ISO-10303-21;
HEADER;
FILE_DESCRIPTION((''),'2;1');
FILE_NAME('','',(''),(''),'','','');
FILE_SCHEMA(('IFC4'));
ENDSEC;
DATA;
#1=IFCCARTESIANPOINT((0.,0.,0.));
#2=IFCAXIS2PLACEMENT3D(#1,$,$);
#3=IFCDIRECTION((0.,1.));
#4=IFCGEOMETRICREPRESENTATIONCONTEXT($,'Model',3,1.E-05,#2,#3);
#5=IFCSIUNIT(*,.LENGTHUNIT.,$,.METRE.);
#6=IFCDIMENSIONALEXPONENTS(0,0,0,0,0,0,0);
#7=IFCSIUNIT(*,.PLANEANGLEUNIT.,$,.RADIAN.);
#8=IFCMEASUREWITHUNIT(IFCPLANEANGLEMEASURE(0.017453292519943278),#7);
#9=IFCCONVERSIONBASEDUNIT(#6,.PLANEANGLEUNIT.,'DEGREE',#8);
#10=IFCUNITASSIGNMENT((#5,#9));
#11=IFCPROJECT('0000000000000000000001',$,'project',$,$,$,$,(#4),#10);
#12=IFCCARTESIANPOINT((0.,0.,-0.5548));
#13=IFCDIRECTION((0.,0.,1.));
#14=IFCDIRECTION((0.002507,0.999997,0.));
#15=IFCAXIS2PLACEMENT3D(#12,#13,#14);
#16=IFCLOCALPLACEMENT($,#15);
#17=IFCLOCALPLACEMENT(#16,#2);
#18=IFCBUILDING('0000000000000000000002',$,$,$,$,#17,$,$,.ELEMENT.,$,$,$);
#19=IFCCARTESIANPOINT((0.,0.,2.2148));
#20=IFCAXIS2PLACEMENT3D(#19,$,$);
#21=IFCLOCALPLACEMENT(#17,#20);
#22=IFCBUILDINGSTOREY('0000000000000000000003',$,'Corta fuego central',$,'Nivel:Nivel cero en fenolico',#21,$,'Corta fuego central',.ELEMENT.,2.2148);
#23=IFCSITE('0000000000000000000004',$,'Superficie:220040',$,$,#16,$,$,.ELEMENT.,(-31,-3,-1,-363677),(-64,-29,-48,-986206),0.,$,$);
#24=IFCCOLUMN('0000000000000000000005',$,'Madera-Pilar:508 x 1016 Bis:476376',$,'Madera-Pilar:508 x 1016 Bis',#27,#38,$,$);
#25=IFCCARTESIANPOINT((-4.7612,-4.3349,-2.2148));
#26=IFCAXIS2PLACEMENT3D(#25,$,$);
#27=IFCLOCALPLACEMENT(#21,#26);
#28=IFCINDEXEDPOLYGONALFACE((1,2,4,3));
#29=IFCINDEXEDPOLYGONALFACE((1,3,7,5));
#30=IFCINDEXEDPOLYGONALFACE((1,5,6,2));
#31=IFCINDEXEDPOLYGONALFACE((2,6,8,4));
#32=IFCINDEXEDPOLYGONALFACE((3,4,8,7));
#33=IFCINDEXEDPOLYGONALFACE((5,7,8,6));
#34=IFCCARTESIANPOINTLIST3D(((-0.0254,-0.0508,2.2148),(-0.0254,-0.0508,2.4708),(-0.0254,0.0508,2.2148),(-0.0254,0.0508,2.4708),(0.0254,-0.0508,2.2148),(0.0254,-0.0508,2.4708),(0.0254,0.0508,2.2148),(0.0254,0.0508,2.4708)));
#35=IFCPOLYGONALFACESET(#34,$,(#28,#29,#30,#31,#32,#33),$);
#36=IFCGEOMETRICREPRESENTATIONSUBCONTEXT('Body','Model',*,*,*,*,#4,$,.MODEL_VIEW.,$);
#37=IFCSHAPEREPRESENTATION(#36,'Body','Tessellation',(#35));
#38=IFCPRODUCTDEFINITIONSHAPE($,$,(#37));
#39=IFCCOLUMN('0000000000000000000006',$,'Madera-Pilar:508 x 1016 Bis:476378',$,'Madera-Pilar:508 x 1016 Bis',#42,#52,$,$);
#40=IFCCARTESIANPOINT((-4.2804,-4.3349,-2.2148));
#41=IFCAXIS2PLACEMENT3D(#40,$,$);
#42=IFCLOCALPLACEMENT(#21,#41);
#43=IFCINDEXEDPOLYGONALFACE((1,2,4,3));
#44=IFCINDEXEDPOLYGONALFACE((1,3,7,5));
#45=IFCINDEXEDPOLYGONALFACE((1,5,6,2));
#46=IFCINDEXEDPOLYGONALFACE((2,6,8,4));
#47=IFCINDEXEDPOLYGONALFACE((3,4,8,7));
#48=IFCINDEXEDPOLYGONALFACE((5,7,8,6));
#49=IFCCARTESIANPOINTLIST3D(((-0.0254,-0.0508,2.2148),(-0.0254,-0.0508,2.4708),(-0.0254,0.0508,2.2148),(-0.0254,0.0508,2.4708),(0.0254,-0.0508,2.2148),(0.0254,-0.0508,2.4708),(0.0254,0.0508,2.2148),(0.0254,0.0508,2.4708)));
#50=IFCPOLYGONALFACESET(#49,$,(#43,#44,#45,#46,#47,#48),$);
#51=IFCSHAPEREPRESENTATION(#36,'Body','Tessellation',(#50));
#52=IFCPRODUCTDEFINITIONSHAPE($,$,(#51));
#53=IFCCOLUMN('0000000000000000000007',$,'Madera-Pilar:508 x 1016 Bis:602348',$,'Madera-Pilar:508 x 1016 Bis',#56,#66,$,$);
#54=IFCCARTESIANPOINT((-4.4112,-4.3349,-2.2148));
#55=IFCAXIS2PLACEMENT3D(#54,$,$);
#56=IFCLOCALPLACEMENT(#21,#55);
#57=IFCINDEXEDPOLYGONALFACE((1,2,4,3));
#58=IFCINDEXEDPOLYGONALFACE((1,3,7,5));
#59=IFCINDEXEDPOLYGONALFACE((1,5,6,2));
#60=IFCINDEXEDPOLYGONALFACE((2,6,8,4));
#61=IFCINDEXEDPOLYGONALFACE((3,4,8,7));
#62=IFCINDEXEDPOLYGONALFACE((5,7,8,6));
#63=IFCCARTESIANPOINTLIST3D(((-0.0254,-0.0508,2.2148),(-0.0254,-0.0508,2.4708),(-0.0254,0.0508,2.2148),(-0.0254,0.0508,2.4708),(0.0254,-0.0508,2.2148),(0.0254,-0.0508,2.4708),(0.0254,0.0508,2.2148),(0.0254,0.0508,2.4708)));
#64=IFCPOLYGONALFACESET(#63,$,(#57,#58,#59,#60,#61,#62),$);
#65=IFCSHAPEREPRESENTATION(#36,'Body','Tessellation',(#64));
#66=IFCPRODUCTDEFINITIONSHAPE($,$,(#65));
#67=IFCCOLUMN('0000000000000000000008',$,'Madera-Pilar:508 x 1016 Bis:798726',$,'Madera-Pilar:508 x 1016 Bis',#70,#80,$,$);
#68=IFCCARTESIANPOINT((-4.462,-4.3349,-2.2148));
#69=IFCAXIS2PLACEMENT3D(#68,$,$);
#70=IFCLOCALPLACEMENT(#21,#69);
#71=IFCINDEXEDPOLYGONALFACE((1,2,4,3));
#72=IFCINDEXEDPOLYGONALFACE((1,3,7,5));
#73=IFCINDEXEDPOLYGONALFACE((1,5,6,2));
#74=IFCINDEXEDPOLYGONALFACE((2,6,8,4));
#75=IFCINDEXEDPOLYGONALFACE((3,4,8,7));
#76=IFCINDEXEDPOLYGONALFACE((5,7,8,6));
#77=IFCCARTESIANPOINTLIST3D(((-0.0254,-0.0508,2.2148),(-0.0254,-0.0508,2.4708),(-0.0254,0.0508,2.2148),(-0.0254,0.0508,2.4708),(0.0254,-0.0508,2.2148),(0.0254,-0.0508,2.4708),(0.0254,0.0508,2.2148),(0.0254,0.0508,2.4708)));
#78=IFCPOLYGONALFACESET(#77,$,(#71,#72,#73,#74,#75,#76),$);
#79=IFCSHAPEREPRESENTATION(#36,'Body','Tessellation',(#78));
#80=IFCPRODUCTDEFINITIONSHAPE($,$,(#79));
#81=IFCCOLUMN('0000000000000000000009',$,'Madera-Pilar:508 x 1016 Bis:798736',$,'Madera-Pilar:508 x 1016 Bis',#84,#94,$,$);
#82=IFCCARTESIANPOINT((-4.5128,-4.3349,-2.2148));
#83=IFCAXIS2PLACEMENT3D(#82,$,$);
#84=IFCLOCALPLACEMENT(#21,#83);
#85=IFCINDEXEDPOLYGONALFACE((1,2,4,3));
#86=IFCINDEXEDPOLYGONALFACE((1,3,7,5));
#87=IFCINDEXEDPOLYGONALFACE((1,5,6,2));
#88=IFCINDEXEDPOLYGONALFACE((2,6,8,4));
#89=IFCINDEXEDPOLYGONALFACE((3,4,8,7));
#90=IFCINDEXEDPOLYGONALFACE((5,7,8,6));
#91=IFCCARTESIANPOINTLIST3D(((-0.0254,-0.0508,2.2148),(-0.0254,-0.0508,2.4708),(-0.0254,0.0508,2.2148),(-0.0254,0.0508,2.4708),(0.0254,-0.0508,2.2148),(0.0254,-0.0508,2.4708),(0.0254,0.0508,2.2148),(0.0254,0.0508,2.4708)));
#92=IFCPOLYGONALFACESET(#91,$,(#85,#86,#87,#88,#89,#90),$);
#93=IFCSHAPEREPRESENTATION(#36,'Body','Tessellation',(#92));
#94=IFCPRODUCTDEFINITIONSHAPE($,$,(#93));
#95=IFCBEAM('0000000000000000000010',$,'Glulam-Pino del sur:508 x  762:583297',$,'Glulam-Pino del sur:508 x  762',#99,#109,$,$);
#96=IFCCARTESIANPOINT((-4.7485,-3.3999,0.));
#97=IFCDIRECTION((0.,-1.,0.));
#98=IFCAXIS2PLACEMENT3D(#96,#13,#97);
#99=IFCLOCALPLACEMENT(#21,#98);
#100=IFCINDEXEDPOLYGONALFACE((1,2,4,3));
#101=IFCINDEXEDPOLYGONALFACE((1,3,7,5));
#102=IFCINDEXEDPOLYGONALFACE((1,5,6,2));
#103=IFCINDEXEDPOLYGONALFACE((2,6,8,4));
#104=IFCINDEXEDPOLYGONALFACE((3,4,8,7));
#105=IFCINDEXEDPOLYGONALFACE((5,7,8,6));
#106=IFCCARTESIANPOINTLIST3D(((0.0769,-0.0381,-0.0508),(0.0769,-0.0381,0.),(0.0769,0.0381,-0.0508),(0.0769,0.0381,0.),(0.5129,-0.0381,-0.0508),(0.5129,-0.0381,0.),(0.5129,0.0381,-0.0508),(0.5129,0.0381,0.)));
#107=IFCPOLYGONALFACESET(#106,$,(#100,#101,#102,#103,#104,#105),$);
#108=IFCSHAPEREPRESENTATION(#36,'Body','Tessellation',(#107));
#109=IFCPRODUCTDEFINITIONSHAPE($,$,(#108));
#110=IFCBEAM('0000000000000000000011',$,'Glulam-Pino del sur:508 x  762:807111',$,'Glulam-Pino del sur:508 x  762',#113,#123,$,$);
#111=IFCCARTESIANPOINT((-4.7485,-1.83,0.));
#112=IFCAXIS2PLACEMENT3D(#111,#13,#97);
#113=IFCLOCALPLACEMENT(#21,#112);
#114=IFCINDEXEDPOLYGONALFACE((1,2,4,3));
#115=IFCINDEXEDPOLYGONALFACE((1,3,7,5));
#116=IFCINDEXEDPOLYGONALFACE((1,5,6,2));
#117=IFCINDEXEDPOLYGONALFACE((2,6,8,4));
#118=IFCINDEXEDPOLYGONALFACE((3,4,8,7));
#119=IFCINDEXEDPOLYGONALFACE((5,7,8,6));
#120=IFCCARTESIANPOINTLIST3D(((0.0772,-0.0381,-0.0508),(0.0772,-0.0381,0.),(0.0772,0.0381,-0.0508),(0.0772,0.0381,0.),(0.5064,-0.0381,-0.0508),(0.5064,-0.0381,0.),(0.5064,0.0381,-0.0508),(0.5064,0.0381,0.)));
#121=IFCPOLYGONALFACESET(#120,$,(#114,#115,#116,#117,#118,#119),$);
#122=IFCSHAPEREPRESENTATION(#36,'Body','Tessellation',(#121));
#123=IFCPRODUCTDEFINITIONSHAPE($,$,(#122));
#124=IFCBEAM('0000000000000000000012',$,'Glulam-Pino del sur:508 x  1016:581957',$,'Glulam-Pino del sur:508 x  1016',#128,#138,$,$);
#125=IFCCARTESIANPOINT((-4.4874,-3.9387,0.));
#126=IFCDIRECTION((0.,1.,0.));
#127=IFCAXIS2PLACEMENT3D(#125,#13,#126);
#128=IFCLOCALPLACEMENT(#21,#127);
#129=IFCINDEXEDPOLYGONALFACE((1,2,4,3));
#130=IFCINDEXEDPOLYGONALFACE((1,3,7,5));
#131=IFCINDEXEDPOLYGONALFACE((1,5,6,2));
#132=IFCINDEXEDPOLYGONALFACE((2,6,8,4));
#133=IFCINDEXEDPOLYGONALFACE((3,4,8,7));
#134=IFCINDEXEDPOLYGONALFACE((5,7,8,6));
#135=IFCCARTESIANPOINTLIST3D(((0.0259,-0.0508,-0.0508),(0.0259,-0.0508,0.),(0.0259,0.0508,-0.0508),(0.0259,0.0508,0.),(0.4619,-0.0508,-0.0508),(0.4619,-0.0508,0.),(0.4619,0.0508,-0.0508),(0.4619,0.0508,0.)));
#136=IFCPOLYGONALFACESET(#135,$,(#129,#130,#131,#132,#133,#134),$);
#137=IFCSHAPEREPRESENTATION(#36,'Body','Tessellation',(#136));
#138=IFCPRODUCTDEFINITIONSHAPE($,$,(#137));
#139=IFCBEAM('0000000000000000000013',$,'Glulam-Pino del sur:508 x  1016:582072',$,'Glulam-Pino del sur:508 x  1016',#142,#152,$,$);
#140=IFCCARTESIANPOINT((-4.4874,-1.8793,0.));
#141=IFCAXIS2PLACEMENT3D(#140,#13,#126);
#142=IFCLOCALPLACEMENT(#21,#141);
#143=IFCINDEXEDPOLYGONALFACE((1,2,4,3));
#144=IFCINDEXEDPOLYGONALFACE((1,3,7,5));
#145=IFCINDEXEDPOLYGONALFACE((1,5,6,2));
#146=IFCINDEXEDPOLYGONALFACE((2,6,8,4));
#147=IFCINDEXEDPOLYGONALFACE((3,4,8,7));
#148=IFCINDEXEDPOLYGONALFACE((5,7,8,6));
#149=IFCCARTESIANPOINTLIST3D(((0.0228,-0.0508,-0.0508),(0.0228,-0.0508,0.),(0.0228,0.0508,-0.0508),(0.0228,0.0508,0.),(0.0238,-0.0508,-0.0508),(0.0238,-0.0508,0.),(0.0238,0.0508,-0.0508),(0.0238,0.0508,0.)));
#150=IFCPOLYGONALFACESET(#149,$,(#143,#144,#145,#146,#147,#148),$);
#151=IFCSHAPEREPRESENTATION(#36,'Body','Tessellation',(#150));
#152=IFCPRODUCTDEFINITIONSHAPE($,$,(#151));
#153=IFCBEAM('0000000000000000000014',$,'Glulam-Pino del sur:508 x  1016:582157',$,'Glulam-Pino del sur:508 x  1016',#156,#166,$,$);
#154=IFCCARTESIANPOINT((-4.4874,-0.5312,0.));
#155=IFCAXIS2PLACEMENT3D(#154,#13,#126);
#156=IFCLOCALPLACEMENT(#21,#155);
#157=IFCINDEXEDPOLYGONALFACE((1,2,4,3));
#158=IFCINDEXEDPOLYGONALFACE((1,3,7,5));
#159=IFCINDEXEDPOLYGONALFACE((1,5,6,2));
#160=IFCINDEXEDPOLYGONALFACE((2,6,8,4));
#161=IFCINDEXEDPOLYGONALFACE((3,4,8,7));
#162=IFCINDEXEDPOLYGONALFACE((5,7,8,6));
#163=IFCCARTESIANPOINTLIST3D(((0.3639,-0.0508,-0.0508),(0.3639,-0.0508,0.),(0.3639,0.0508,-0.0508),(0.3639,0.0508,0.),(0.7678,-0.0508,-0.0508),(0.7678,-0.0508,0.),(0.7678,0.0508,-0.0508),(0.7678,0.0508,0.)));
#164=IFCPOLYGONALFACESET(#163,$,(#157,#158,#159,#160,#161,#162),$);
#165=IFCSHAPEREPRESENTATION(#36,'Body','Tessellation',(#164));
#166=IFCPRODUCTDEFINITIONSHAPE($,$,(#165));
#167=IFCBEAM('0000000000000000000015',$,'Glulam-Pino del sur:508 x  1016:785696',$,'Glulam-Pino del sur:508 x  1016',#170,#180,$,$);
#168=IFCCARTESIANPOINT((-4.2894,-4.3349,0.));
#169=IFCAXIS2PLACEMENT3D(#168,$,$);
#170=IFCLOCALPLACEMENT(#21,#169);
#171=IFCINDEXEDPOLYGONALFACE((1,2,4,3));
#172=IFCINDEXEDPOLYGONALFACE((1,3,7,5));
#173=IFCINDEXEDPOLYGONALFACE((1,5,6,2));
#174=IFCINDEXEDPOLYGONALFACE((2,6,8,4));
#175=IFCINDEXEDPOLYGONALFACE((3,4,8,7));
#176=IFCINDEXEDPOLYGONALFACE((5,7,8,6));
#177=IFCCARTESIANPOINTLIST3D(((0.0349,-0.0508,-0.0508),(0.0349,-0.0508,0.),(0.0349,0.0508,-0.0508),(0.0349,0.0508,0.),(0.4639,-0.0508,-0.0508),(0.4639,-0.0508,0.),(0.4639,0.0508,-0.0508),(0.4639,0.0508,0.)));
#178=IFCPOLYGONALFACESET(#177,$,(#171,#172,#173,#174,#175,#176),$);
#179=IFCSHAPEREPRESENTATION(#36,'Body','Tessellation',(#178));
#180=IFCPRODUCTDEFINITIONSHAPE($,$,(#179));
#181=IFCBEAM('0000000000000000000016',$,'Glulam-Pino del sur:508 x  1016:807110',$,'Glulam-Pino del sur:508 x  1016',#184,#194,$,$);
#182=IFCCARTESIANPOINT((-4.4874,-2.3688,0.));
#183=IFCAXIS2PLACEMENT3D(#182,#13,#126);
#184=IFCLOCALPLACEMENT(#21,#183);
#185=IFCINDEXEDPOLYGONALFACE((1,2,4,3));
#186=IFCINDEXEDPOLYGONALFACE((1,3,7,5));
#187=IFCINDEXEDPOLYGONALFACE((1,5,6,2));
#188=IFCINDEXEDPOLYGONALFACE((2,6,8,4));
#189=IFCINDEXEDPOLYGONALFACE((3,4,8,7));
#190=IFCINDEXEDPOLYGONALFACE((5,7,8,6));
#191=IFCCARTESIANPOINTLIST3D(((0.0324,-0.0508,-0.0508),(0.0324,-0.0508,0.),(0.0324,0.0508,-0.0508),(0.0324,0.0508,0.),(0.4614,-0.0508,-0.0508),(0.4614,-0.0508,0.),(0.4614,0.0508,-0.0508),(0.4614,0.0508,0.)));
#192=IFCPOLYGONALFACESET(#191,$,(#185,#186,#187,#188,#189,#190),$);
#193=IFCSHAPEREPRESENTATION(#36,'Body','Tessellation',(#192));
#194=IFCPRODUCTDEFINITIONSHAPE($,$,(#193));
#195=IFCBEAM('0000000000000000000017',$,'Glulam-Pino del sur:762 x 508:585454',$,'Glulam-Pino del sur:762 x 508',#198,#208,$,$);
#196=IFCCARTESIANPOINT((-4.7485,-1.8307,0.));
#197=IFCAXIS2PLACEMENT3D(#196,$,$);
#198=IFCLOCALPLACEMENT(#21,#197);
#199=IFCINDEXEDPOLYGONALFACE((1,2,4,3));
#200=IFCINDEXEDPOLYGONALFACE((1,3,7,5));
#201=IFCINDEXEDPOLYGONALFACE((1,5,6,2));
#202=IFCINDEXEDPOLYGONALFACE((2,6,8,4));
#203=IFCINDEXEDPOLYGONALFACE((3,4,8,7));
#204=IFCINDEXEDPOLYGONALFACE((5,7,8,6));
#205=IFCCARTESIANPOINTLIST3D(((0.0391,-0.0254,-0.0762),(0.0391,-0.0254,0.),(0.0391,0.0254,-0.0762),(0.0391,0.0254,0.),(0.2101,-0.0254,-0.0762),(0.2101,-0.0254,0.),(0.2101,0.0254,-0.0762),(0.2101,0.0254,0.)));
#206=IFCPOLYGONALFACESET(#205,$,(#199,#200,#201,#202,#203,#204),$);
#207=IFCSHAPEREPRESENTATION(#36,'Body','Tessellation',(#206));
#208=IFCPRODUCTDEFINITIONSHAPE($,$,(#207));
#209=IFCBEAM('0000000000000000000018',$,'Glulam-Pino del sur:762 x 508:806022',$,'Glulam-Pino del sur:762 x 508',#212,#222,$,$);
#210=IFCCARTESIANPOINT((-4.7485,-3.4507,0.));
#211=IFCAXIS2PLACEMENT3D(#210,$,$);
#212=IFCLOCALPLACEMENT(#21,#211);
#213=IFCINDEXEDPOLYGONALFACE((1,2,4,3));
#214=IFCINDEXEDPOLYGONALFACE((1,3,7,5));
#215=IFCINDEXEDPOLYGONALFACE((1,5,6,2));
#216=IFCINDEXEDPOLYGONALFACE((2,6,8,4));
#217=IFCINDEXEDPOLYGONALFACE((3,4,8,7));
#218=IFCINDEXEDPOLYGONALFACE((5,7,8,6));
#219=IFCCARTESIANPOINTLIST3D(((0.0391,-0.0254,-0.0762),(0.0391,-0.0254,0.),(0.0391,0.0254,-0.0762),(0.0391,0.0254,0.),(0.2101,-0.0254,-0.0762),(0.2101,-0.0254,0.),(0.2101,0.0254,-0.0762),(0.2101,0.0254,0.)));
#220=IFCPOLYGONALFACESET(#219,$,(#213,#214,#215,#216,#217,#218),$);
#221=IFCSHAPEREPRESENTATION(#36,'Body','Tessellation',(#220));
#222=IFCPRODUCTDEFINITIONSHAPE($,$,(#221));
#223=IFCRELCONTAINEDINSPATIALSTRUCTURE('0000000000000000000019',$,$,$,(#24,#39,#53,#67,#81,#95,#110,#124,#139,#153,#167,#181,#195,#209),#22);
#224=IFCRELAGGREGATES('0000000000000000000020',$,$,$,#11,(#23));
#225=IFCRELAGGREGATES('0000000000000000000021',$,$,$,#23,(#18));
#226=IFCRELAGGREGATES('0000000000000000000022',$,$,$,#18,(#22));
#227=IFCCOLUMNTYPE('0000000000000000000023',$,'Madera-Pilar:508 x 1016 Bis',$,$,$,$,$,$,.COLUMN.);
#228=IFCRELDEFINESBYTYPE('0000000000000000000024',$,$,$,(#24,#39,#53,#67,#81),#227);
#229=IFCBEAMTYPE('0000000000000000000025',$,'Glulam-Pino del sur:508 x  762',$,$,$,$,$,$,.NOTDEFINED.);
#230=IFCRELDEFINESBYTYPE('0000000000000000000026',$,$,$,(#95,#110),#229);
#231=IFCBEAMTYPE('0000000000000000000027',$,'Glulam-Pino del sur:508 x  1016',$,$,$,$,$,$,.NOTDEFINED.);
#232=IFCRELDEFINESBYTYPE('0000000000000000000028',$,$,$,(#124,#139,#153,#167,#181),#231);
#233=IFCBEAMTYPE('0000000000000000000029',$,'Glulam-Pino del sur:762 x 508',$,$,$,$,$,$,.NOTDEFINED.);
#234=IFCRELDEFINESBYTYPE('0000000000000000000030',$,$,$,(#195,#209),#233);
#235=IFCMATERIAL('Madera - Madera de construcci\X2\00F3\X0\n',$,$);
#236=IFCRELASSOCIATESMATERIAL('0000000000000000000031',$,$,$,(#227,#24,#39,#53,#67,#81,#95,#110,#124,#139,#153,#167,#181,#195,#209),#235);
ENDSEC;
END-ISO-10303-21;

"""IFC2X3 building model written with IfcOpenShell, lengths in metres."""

from ifc_helpers import new_model, entity, si_unit, converted_unit, direction, frame, frame_2d, origin, origin_2d_with_axis, place, context, subcontext, project, spatial, rectangle, extrude, source, transform, mapped, material, type_object, type_shapes, element, save


model = new_model("IFC2X3")

# Units and contexts
model_context = context("Model", 3, precision=1e-05, world=origin(), true_north=direction((0.0, 1.0)))
body_context = subcontext(model_context, "Body", "Model", "MODEL_VIEW")
ifc_project = project(units=[si_unit("LENGTHUNIT", "METRE"), converted_unit("PLANEANGLEUNIT", "DEGREE", entity("IfcPlaneAngleMeasure", 0.017453292519943278), si_unit("PLANEANGLEUNIT", "RADIAN"), dimensions=[0, 0, 0, 0, 0, 0, 0])], contexts=[model_context])

# Site, building, storey
site_placement = place(None, frame((0.0, 0.0, -0.5548), z_axis=(0.0, 0.0, 1.0), x_axis=(0.002507, 0.999997, 0.0)))
site = spatial("IfcSite", under=ifc_project, at=site_placement, Name="Superficie:220040", CompositionType="ELEMENT", RefLatitude=(-31, -3, -1, -363677), RefLongitude=(-64, -29, -48, -986206), RefElevation=0.0)
building_placement = place(site_placement, origin())
building = spatial("IfcBuilding", under=site, at=building_placement, CompositionType="ELEMENT")
storey_placement = place(building_placement, frame((0.0, 0.0, 2.2148)))
storey = spatial("IfcBuildingStorey", under=building, at=storey_placement, Name="Corta fuego central", ObjectType="Nivel:Nivel cero en fenolico", LongName="Corta fuego central", CompositionType="ELEMENT", Elevation=2.2148)

# Columns
ifc_material_1 = material(Name="Madera - Madera de construcción")
column_type = type_object("IfcColumnType", Name="Madera-Pilar:508 x 1016 Bis", PredefinedType="COLUMN", material=ifc_material_1)
shared_shape = source(origin(), body_context, "Body", "SweptSolid", [
    extrude(rectangle(XDim=0.0508, YDim=0.1016, at=origin_2d_with_axis()), frame((0.0, 0.0, 2.2148), z_axis=(0.0, 0.0, 1.0), x_axis=(-1.0, 0.0, 0.0)), (0.0, 0.0, 1.0), 0.256),
])
type_shapes(column_type, [shared_shape])
for number, where, name in (
    (1, (-4.7612, -4.3349, -2.2148), "Madera-Pilar:508 x 1016 Bis:476376"),
    (2, (-4.2804, -4.3349, -2.2148), "Madera-Pilar:508 x 1016 Bis:476378"),
    (3, (-4.4112, -4.3349, -2.2148), "Madera-Pilar:508 x 1016 Bis:602348"),
    (4, (-4.462, -4.3349, -2.2148), "Madera-Pilar:508 x 1016 Bis:798726"),
    (5, (-4.5128, -4.3349, -2.2148), "Madera-Pilar:508 x 1016 Bis:798736"),
):
    element("IfcColumn", number, at=place(storey_placement, frame(where)), inside=storey, type_object=column_type, material=ifc_material_1, Name=name, ObjectType="Madera-Pilar:508 x 1016 Bis", context=body_context, shape_type="MappedRepresentation", body=[
        mapped(shared_shape, transform((0.0, 0.0, 0.0), scale=1.0)),
    ])

# Beams
beam_type_1 = type_object("IfcBeamType", Name="Glulam-Pino del sur:508 x  762", PredefinedType="NOTDEFINED")
beam_1_placement = place(storey_placement, frame((-4.7485, -3.3999, 0.0), z_axis=(0.0, 0.0, 1.0), x_axis=(0.0, -1.0, 0.0)))
element("IfcBeam", 6, at=beam_1_placement, inside=storey, type_object=beam_type_1, material=ifc_material_1, Name="Glulam-Pino del sur:508 x  762:583297", ObjectType="Glulam-Pino del sur:508 x  762", context=body_context, shape_type="SweptSolid", body=[
    extrude(rectangle(XDim=0.0508, YDim=0.0762, at=frame_2d((0.0, 0.0), x_axis=(1.0, 0.0))), frame((0.0769, 0.0, -0.0254), z_axis=(1.0, 0.0, 0.0), x_axis=(0.0, 0.0, -1.0)), (0.0, 0.0, 1.0), 0.436),
])
beam_2_placement = place(storey_placement, frame((-4.7485, -1.83, 0.0), z_axis=(0.0, 0.0, 1.0), x_axis=(0.0, -1.0, 0.0)))
element("IfcBeam", 7, at=beam_2_placement, inside=storey, type_object=beam_type_1, material=ifc_material_1, Name="Glulam-Pino del sur:508 x  762:807111", ObjectType="Glulam-Pino del sur:508 x  762", context=body_context, shape_type="SweptSolid", body=[
    extrude(rectangle(XDim=0.0508, YDim=0.0762, at=frame_2d((0.0, 0.0), x_axis=(1.0, 0.0))), frame((0.0772, 0.0, -0.0254), z_axis=(1.0, 0.0, 0.0), x_axis=(0.0, 0.0, -1.0)), (0.0, 0.0, 1.0), 0.4292),
])
beam_type_2 = type_object("IfcBeamType", Name="Glulam-Pino del sur:508 x  1016", PredefinedType="NOTDEFINED")
beam_3_placement = place(storey_placement, frame((-4.4874, -3.9387, 0.0), z_axis=(0.0, 0.0, 1.0), x_axis=(0.0, 1.0, 0.0)))
element("IfcBeam", 8, at=beam_3_placement, inside=storey, type_object=beam_type_2, material=ifc_material_1, Name="Glulam-Pino del sur:508 x  1016:581957", ObjectType="Glulam-Pino del sur:508 x  1016", context=body_context, shape_type="SweptSolid", body=[
    extrude(rectangle(XDim=0.0508, YDim=0.1016, at=frame_2d((0.0, 0.0), x_axis=(1.0, 0.0))), frame((0.0259, 0.0, -0.0254), z_axis=(1.0, 0.0, 0.0), x_axis=(0.0, 0.0, -1.0)), (0.0, 0.0, 1.0), 0.436),
])
beam_4_placement = place(storey_placement, frame((-4.4874, -1.8793, 0.0), z_axis=(0.0, 0.0, 1.0), x_axis=(0.0, 1.0, 0.0)))
element("IfcBeam", 9, at=beam_4_placement, inside=storey, type_object=beam_type_2, material=ifc_material_1, Name="Glulam-Pino del sur:508 x  1016:582072", ObjectType="Glulam-Pino del sur:508 x  1016", context=body_context, shape_type="SweptSolid", body=[
    extrude(rectangle(XDim=0.0508, YDim=0.1016, at=frame_2d((0.0, 0.0), x_axis=(1.0, 0.0))), frame((0.0228, 0.0, -0.0254), z_axis=(1.0, 0.0, 0.0), x_axis=(0.0, 0.0, -1.0)), (0.0, 0.0, 1.0), 0.001),
])
beam_5_placement = place(storey_placement, frame((-4.4874, -0.5312, 0.0), z_axis=(0.0, 0.0, 1.0), x_axis=(0.0, 1.0, 0.0)))
element("IfcBeam", 10, at=beam_5_placement, inside=storey, type_object=beam_type_2, material=ifc_material_1, Name="Glulam-Pino del sur:508 x  1016:582157", ObjectType="Glulam-Pino del sur:508 x  1016", context=body_context, shape_type="SweptSolid", body=[
    extrude(rectangle(XDim=0.0508, YDim=0.1016, at=frame_2d((0.0, 0.0), x_axis=(1.0, 0.0))), frame((0.3639, 0.0, -0.0254), z_axis=(1.0, 0.0, 0.0), x_axis=(0.0, 0.0, -1.0)), (0.0, 0.0, 1.0), 0.4038),
])
beam_6_placement = place(storey_placement, frame((-4.2894, -4.3349, 0.0)))
element("IfcBeam", 11, at=beam_6_placement, inside=storey, type_object=beam_type_2, material=ifc_material_1, Name="Glulam-Pino del sur:508 x  1016:785696", ObjectType="Glulam-Pino del sur:508 x  1016", context=body_context, shape_type="SweptSolid", body=[
    extrude(rectangle(XDim=0.0508, YDim=0.1016, at=frame_2d((0.0, 0.0), x_axis=(1.0, 0.0))), frame((0.0349, 0.0, -0.0254), z_axis=(1.0, 0.0, 0.0), x_axis=(0.0, 0.0, -1.0)), (0.0, 0.0, 1.0), 0.429),
])
beam_7_placement = place(storey_placement, frame((-4.4874, -2.3688, 0.0), z_axis=(0.0, 0.0, 1.0), x_axis=(0.0, 1.0, 0.0)))
element("IfcBeam", 12, at=beam_7_placement, inside=storey, type_object=beam_type_2, material=ifc_material_1, Name="Glulam-Pino del sur:508 x  1016:807110", ObjectType="Glulam-Pino del sur:508 x  1016", context=body_context, shape_type="SweptSolid", body=[
    extrude(rectangle(XDim=0.0508, YDim=0.1016, at=frame_2d((0.0, 0.0), x_axis=(1.0, 0.0))), frame((0.0324, 0.0, -0.0254), z_axis=(1.0, 0.0, 0.0), x_axis=(0.0, 0.0, -1.0)), (0.0, 0.0, 1.0), 0.429),
])
beam_type_3 = type_object("IfcBeamType", Name="Glulam-Pino del sur:762 x 508", PredefinedType="NOTDEFINED")
beam_8_placement = place(storey_placement, frame((-4.7485, -1.8307, 0.0)))
element("IfcBeam", 13, at=beam_8_placement, inside=storey, type_object=beam_type_3, material=ifc_material_1, Name="Glulam-Pino del sur:762 x 508:585454", ObjectType="Glulam-Pino del sur:762 x 508", context=body_context, shape_type="SweptSolid", body=[
    extrude(rectangle(XDim=0.0762, YDim=0.0508, at=frame_2d((0.0, 0.0), x_axis=(1.0, 0.0))), frame((0.0391, 0.0, -0.0381), z_axis=(1.0, 0.0, 0.0), x_axis=(0.0, 0.0, -1.0)), (0.0, 0.0, 1.0), 0.171),
])
beam_9_placement = place(storey_placement, frame((-4.7485, -3.4507, 0.0)))
element("IfcBeam", 14, at=beam_9_placement, inside=storey, type_object=beam_type_3, material=ifc_material_1, Name="Glulam-Pino del sur:762 x 508:806022", ObjectType="Glulam-Pino del sur:762 x 508", context=body_context, shape_type="SweptSolid", body=[
    extrude(rectangle(XDim=0.0762, YDim=0.0508, at=origin_2d_with_axis()), frame((0.0391, 0.0, -0.0381), z_axis=(1.0, 0.0, 0.0), x_axis=(0.0, 0.0, -1.0)), (0.0, 0.0, 1.0), 0.171),
])

save(model, "model.ifc")
